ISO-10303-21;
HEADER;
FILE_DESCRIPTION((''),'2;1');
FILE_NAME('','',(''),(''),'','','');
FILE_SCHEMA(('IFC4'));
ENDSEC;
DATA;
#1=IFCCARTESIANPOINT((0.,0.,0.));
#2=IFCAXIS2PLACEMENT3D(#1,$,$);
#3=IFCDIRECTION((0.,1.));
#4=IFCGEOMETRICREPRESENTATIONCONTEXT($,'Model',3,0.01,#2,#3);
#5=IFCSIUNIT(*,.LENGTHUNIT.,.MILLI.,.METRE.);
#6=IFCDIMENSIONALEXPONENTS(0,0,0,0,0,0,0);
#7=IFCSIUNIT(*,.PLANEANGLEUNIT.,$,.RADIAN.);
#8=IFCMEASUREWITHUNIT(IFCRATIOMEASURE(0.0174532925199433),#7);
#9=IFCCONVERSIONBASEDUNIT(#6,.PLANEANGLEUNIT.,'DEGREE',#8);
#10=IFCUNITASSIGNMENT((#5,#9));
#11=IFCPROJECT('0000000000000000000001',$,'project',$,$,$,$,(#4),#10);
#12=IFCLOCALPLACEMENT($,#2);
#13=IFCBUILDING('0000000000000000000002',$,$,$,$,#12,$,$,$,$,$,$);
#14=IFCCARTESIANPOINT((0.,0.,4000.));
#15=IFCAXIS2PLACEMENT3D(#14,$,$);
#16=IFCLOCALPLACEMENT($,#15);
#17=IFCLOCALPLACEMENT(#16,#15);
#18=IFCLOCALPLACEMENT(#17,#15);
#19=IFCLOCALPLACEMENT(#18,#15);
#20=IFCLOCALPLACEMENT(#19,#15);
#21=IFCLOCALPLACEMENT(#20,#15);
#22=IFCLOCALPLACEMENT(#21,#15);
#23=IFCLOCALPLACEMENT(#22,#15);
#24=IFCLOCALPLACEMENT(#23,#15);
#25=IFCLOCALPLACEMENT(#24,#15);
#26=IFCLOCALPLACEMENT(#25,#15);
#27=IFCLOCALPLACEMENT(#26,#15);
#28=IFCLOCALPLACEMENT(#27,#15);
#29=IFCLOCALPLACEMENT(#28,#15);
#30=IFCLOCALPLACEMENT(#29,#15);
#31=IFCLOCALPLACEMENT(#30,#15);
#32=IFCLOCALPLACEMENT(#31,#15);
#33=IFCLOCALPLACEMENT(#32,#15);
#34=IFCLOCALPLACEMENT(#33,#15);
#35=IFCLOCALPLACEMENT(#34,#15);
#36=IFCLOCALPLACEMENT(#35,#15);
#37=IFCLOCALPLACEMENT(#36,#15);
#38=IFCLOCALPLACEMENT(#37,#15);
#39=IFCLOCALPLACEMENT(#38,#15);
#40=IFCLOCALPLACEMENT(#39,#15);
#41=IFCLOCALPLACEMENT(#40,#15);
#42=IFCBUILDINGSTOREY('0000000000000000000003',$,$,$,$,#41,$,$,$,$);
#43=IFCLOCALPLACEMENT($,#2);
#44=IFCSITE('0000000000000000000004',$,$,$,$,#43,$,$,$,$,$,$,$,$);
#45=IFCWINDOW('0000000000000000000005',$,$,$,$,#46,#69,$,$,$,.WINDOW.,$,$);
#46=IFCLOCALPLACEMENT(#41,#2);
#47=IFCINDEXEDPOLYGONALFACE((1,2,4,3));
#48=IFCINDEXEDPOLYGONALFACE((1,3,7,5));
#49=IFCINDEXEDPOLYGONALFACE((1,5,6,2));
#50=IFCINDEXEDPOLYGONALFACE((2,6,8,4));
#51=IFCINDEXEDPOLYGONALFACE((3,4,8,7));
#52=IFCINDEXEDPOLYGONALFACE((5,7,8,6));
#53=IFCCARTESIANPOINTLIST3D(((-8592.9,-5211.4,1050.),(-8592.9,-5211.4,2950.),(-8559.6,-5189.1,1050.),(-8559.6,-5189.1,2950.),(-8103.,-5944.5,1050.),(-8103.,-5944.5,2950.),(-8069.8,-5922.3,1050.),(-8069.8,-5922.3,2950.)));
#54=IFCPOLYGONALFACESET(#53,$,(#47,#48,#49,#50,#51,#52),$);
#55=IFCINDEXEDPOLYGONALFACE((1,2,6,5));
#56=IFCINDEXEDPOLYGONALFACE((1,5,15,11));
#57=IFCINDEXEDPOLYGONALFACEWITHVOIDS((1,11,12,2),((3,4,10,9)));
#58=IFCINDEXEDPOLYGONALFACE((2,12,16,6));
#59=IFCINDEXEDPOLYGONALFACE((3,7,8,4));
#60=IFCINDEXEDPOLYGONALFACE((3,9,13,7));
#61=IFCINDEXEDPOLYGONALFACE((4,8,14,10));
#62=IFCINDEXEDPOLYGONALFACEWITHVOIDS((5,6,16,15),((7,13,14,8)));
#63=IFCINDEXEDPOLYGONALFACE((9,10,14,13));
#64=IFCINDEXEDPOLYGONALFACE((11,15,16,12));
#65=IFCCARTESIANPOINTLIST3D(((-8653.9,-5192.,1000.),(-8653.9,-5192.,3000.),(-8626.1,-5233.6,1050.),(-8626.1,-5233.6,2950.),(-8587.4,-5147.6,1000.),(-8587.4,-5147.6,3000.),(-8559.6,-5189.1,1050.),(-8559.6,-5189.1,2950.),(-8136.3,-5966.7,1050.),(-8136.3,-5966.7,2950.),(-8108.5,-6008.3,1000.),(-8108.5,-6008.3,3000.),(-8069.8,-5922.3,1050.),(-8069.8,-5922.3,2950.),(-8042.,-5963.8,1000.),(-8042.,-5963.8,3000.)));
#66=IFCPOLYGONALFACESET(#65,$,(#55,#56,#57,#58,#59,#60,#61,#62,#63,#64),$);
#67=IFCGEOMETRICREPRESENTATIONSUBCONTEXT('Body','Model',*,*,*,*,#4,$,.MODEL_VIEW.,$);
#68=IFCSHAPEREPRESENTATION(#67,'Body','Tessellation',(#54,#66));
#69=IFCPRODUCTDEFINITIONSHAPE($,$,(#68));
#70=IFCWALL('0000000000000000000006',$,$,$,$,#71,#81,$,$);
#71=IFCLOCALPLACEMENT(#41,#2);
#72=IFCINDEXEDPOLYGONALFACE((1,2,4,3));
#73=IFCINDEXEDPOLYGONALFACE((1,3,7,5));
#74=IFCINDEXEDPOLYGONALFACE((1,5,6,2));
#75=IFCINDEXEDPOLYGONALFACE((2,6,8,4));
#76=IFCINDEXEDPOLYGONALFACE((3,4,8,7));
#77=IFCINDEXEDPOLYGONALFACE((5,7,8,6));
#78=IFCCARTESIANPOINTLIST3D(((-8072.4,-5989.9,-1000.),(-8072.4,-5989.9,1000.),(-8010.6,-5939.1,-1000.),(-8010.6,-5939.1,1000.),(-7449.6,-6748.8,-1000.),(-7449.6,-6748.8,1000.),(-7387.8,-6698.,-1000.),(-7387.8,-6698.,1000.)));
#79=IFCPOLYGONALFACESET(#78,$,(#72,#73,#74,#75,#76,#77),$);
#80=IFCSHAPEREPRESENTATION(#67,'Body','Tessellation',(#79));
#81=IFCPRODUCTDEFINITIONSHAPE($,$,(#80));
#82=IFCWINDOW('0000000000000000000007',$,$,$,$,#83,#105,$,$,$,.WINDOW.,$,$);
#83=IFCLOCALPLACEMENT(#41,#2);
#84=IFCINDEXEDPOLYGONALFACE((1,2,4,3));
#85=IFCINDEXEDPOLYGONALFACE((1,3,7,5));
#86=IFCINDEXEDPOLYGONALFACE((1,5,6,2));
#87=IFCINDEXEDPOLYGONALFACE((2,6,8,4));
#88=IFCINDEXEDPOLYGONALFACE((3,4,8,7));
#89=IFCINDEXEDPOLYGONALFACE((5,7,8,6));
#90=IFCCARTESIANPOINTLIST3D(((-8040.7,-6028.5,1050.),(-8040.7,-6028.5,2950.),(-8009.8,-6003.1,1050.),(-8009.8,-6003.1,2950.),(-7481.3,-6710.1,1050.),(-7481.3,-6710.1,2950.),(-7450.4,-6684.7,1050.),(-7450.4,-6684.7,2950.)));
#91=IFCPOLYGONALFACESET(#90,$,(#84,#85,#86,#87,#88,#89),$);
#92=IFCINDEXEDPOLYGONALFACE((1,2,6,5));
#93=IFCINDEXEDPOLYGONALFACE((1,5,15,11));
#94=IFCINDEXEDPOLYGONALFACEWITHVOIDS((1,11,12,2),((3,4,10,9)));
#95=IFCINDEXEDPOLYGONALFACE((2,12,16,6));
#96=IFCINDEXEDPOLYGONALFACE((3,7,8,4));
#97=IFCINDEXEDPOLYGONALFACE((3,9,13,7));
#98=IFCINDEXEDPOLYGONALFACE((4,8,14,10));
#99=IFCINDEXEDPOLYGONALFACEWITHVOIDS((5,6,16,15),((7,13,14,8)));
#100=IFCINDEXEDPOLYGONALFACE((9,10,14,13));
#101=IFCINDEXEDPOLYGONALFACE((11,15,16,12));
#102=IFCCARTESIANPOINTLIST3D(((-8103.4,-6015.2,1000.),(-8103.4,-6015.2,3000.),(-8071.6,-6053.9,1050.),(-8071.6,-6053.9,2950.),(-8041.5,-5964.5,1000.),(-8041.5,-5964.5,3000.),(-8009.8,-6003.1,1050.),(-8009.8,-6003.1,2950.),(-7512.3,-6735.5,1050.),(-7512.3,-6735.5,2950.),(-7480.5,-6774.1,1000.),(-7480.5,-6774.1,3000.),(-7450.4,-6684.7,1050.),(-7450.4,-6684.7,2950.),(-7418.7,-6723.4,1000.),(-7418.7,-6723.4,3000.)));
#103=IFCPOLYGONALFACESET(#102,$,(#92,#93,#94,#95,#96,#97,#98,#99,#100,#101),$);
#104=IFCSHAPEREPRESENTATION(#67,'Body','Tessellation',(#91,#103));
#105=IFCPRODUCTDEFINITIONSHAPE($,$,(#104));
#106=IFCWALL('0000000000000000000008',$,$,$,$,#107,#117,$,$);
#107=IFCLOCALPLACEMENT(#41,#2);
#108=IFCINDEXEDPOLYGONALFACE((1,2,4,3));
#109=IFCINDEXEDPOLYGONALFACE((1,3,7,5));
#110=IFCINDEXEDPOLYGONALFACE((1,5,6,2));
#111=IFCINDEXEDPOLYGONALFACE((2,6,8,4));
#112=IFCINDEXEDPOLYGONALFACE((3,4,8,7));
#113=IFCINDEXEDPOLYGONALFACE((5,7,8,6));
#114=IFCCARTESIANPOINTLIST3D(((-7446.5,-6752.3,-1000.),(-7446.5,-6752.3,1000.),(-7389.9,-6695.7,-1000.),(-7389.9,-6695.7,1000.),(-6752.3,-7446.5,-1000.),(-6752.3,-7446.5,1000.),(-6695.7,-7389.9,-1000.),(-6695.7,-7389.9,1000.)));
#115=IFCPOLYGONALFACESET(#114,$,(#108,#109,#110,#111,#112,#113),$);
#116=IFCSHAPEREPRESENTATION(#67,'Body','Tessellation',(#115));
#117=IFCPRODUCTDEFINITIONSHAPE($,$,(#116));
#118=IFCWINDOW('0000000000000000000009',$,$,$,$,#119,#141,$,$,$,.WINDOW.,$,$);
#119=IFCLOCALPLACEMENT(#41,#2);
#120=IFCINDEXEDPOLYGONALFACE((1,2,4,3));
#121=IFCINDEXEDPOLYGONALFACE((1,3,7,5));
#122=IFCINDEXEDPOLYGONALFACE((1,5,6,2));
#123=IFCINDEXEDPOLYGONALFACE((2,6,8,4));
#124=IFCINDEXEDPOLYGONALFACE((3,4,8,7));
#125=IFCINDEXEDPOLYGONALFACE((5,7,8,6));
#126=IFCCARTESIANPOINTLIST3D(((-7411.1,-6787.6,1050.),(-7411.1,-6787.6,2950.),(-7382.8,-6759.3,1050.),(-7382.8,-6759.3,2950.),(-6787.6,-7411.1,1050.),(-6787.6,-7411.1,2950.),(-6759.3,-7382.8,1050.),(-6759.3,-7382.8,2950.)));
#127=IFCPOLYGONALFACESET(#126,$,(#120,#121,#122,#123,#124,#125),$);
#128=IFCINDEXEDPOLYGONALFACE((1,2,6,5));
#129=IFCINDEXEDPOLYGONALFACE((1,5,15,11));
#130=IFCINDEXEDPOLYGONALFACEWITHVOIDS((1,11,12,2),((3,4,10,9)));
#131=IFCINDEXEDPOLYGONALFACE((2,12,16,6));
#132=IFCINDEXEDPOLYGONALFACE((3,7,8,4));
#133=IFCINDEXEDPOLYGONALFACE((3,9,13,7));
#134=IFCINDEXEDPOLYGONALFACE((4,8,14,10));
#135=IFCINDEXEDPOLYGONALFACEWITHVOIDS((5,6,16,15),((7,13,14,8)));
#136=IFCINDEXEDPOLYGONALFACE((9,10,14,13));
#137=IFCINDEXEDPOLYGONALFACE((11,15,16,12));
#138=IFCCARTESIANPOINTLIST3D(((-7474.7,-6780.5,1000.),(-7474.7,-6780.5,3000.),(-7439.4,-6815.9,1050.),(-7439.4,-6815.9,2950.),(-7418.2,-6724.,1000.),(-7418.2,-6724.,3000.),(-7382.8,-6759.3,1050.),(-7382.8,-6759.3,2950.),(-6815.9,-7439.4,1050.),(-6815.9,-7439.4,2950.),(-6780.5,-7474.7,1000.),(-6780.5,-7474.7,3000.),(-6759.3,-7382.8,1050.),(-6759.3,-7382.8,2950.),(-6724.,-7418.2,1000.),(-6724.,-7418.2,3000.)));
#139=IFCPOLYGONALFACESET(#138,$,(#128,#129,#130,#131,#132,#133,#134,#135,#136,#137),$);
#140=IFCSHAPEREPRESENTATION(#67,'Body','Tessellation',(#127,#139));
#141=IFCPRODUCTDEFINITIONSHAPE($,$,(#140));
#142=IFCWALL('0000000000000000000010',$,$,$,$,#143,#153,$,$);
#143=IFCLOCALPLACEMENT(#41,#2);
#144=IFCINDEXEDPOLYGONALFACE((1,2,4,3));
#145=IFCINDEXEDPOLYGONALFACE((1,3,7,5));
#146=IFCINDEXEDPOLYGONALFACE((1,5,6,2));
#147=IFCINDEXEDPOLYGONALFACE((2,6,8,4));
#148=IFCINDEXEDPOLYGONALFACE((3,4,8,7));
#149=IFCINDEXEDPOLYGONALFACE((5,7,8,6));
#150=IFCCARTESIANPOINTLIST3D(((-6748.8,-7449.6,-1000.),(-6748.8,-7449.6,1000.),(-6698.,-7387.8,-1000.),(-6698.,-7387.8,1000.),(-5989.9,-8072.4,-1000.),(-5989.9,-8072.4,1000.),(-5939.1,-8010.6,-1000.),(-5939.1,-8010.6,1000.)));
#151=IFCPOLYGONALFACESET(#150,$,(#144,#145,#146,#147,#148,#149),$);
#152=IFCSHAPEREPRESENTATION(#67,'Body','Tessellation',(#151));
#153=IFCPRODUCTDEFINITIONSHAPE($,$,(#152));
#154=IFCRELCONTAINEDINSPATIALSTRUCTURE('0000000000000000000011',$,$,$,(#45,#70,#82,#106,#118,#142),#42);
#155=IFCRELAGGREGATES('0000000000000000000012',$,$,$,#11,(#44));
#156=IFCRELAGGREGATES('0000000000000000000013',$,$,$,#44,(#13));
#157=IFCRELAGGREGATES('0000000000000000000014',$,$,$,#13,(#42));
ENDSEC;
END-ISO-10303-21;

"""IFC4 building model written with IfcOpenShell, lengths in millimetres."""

from ifc_helpers import new_model, entity, si_unit, converted_unit, direction, frame, origin, origin_2d, place, context, subcontext, project, spatial, rectangle, extrude, element, save


model = new_model("IFC4")

# Units and contexts
model_context = context("Model", 3, precision=0.01, world=origin(), true_north=direction((0.0, 1.0)))
body_context = subcontext(model_context, "Body", "Model", "MODEL_VIEW")
ifc_project = project(units=[si_unit("LENGTHUNIT", "METRE", prefix="MILLI"), converted_unit("PLANEANGLEUNIT", "DEGREE", entity("IfcRatioMeasure", 0.0174532925199433), si_unit("PLANEANGLEUNIT", "RADIAN"), dimensions=[0, 0, 0, 0, 0, 0, 0])], contexts=[model_context])

# Site, building, storey
site_placement = place(None, origin())
site = spatial("IfcSite", under=ifc_project, at=site_placement)
building_placement = place(None, origin())
building = spatial("IfcBuilding", under=site, at=building_placement)
placement_1 = place(None, frame((0.0, 0.0, 4000.0)))
placement_2 = place(placement_1, frame((0.0, 0.0, 4000.0)))
placement_3 = place(placement_2, frame((0.0, 0.0, 4000.0)))
placement_4 = place(placement_3, frame((0.0, 0.0, 4000.0)))
placement_5 = place(placement_4, frame((0.0, 0.0, 4000.0)))
placement_6 = place(placement_5, frame((0.0, 0.0, 4000.0)))
placement_7 = place(placement_6, frame((0.0, 0.0, 4000.0)))
placement_8 = place(placement_7, frame((0.0, 0.0, 4000.0)))
placement_9 = place(placement_8, frame((0.0, 0.0, 4000.0)))
placement_10 = place(placement_9, frame((0.0, 0.0, 4000.0)))
placement_11 = place(placement_10, frame((0.0, 0.0, 4000.0)))
placement_12 = place(placement_11, frame((0.0, 0.0, 4000.0)))
placement_13 = place(placement_12, frame((0.0, 0.0, 4000.0)))
placement_14 = place(placement_13, frame((0.0, 0.0, 4000.0)))
placement_15 = place(placement_14, frame((0.0, 0.0, 4000.0)))
placement_16 = place(placement_15, frame((0.0, 0.0, 4000.0)))
placement_17 = place(placement_16, frame((0.0, 0.0, 4000.0)))
placement_18 = place(placement_17, frame((0.0, 0.0, 4000.0)))
placement_19 = place(placement_18, frame((0.0, 0.0, 4000.0)))
placement_20 = place(placement_19, frame((0.0, 0.0, 4000.0)))
placement_21 = place(placement_20, frame((0.0, 0.0, 4000.0)))
placement_22 = place(placement_21, frame((0.0, 0.0, 4000.0)))
placement_23 = place(placement_22, frame((0.0, 0.0, 4000.0)))
placement_24 = place(placement_23, frame((0.0, 0.0, 4000.0)))
placement_25 = place(placement_24, frame((0.0, 0.0, 4000.0)))
storey_placement = place(placement_25, frame((0.0, 0.0, 4000.0)))
storey = spatial("IfcBuildingStorey", under=building, at=storey_placement)

# Shared definitions
cartesian_point_1 = entity("IfcCartesianPoint", [-440.9, -950.0])
shared_polyline = entity("IfcPolyline", [cartesian_point_1, entity("IfcCartesianPoint", [-440.9, 950.0]), entity("IfcCartesianPoint", [-440.9, 950.0]), entity("IfcCartesianPoint", [440.9, 950.0]), entity("IfcCartesianPoint", [440.9, 950.0]), entity("IfcCartesianPoint", [440.9, -950.0]), entity("IfcCartesianPoint", [440.9, -950.0]), entity("IfcCartesianPoint", [-440.9, -950.0]), cartesian_point_1])

# Window
window_1_placement = place(storey_placement, frame((-8314.7, -5555.7, 2000.0), z_axis=(0.0, 0.0, 1.0), x_axis=(5555.703069, -8314.695629, 0.0)))
cartesian_point_2 = entity("IfcCartesianPoint", [-490.9, -1000.0])
element("IfcWindow", 1, at=window_1_placement, inside=storey, PredefinedType="WINDOW", context=body_context, shape_type="SweptSolid", body=[
    entity("IfcExtrudedAreaSolid", entity("IfcArbitraryClosedProfileDef", "AREA", None, shared_polyline), entity("IfcAxis2Placement3D", entity("IfcCartesianPoint", [0.0, 0.0, 0.0]), entity("IfcDirection", [0.0, -1.0, 0.0]), entity("IfcDirection", [1.0, 0.0, 0.0])), entity("IfcDirection", [0.0, 0.0, 1.0]), 40.0),
    entity("IfcExtrudedAreaSolid", entity("IfcArbitraryProfileDefWithVoids", "AREA", None, entity("IfcPolyline", [cartesian_point_2, entity("IfcCartesianPoint", [-490.9, 1000.0]), entity("IfcCartesianPoint", [-490.9, 1000.0]), entity("IfcCartesianPoint", [490.9, 1000.0]), entity("IfcCartesianPoint", [490.9, 1000.0]), entity("IfcCartesianPoint", [490.9, -1000.0]), entity("IfcCartesianPoint", [490.9, -1000.0]), entity("IfcCartesianPoint", [-490.9, -1000.0]), cartesian_point_2]), [shared_polyline]), entity("IfcAxis2Placement3D", entity("IfcCartesianPoint", [0.0, 0.0, 0.0]), entity("IfcDirection", [0.0, -1.0, 0.0]), entity("IfcDirection", [1.0, 0.0, 0.0])), entity("IfcDirection", [0.0, 0.0, 1.0]), 80.0),
])

# Wall
wall_1_placement = place(storey_placement, frame((-7730.1, -6343.9, -1000.0), z_axis=(0.0, 0.0, 1.0), x_axis=(6343.931995, -7730.105228, 0.0)))
element("IfcWall", 2, at=wall_1_placement, inside=storey, context=body_context, shape_type="SweptSolid", body=[
    extrude(rectangle(XDim=981.7, YDim=80.0, at=origin_2d()), origin(), (0.0, 0.0, 1.0), 2000.0),
])

# Window
window_2_placement = place(storey_placement, frame((-7730.1, -6343.9, 2000.0), z_axis=(0.0, 0.0, 1.0), x_axis=(6343.931995, -7730.105228, 0.0)))
cartesian_point_3 = entity("IfcCartesianPoint", [-490.9, -1000.0])
element("IfcWindow", 3, at=window_2_placement, inside=storey, PredefinedType="WINDOW", context=body_context, shape_type="SweptSolid", body=[
    entity("IfcExtrudedAreaSolid", entity("IfcArbitraryClosedProfileDef", "AREA", None, shared_polyline), entity("IfcAxis2Placement3D", entity("IfcCartesianPoint", [0.0, 0.0, 0.0]), entity("IfcDirection", [0.0, -1.0, 0.0]), entity("IfcDirection", [1.0, 0.0, 0.0])), entity("IfcDirection", [0.0, 0.0, 1.0]), 40.0),
    entity("IfcExtrudedAreaSolid", entity("IfcArbitraryProfileDefWithVoids", "AREA", None, entity("IfcPolyline", [cartesian_point_3, entity("IfcCartesianPoint", [-490.9, 1000.0]), entity("IfcCartesianPoint", [-490.9, 1000.0]), entity("IfcCartesianPoint", [490.9, 1000.0]), entity("IfcCartesianPoint", [490.9, 1000.0]), entity("IfcCartesianPoint", [490.9, -1000.0]), entity("IfcCartesianPoint", [490.9, -1000.0]), entity("IfcCartesianPoint", [-490.9, -1000.0]), cartesian_point_3]), [shared_polyline]), entity("IfcAxis2Placement3D", entity("IfcCartesianPoint", [0.0, 0.0, 0.0]), entity("IfcDirection", [0.0, -1.0, 0.0]), entity("IfcDirection", [1.0, 0.0, 0.0])), entity("IfcDirection", [0.0, 0.0, 1.0]), 80.0),
])

# Wall
wall_2_placement = place(storey_placement, frame((-7071.1, -7071.1, -1000.0), z_axis=(0.0, 0.0, 1.0), x_axis=(7071.06732, -7071.068304, 0.0)))
element("IfcWall", 4, at=wall_2_placement, inside=storey, context=body_context, shape_type="SweptSolid", body=[
    extrude(rectangle(XDim=981.7, YDim=80.0, at=origin_2d()), origin(), (0.0, 0.0, 1.0), 2000.0),
])

# Window
window_3_placement = place(storey_placement, frame((-7071.1, -7071.1, 2000.0), z_axis=(0.0, 0.0, 1.0), x_axis=(7071.06732, -7071.068304, 0.0)))
cartesian_point_4 = entity("IfcCartesianPoint", [-490.9, -1000.0])
element("IfcWindow", 5, at=window_3_placement, inside=storey, PredefinedType="WINDOW", context=body_context, shape_type="SweptSolid", body=[
    entity("IfcExtrudedAreaSolid", entity("IfcArbitraryClosedProfileDef", "AREA", None, shared_polyline), entity("IfcAxis2Placement3D", entity("IfcCartesianPoint", [0.0, 0.0, 0.0]), entity("IfcDirection", [0.0, -1.0, 0.0]), entity("IfcDirection", [1.0, 0.0, 0.0])), entity("IfcDirection", [0.0, 0.0, 1.0]), 40.0),
    entity("IfcExtrudedAreaSolid", entity("IfcArbitraryProfileDefWithVoids", "AREA", None, entity("IfcPolyline", [cartesian_point_4, entity("IfcCartesianPoint", [-490.9, 1000.0]), entity("IfcCartesianPoint", [-490.9, 1000.0]), entity("IfcCartesianPoint", [490.9, 1000.0]), entity("IfcCartesianPoint", [490.9, 1000.0]), entity("IfcCartesianPoint", [490.9, -1000.0]), entity("IfcCartesianPoint", [490.9, -1000.0]), entity("IfcCartesianPoint", [-490.9, -1000.0]), cartesian_point_4]), [shared_polyline]), entity("IfcAxis2Placement3D", entity("IfcCartesianPoint", [0.0, 0.0, 0.0]), entity("IfcDirection", [0.0, -1.0, 0.0]), entity("IfcDirection", [1.0, 0.0, 0.0])), entity("IfcDirection", [0.0, 0.0, 1.0]), 80.0),
])

# Wall
wall_3_placement = place(storey_placement, frame((-6343.9, -7730.1, -1000.0), z_axis=(0.0, 0.0, 1.0), x_axis=(7730.104346, -6343.93307, 0.0)))
element("IfcWall", 6, at=wall_3_placement, inside=storey, context=body_context, shape_type="SweptSolid", body=[
    extrude(rectangle(XDim=981.7, YDim=80.0, at=origin_2d()), origin(), (0.0, 0.0, 1.0), 2000.0),
])

save(model, "model.ifc")
